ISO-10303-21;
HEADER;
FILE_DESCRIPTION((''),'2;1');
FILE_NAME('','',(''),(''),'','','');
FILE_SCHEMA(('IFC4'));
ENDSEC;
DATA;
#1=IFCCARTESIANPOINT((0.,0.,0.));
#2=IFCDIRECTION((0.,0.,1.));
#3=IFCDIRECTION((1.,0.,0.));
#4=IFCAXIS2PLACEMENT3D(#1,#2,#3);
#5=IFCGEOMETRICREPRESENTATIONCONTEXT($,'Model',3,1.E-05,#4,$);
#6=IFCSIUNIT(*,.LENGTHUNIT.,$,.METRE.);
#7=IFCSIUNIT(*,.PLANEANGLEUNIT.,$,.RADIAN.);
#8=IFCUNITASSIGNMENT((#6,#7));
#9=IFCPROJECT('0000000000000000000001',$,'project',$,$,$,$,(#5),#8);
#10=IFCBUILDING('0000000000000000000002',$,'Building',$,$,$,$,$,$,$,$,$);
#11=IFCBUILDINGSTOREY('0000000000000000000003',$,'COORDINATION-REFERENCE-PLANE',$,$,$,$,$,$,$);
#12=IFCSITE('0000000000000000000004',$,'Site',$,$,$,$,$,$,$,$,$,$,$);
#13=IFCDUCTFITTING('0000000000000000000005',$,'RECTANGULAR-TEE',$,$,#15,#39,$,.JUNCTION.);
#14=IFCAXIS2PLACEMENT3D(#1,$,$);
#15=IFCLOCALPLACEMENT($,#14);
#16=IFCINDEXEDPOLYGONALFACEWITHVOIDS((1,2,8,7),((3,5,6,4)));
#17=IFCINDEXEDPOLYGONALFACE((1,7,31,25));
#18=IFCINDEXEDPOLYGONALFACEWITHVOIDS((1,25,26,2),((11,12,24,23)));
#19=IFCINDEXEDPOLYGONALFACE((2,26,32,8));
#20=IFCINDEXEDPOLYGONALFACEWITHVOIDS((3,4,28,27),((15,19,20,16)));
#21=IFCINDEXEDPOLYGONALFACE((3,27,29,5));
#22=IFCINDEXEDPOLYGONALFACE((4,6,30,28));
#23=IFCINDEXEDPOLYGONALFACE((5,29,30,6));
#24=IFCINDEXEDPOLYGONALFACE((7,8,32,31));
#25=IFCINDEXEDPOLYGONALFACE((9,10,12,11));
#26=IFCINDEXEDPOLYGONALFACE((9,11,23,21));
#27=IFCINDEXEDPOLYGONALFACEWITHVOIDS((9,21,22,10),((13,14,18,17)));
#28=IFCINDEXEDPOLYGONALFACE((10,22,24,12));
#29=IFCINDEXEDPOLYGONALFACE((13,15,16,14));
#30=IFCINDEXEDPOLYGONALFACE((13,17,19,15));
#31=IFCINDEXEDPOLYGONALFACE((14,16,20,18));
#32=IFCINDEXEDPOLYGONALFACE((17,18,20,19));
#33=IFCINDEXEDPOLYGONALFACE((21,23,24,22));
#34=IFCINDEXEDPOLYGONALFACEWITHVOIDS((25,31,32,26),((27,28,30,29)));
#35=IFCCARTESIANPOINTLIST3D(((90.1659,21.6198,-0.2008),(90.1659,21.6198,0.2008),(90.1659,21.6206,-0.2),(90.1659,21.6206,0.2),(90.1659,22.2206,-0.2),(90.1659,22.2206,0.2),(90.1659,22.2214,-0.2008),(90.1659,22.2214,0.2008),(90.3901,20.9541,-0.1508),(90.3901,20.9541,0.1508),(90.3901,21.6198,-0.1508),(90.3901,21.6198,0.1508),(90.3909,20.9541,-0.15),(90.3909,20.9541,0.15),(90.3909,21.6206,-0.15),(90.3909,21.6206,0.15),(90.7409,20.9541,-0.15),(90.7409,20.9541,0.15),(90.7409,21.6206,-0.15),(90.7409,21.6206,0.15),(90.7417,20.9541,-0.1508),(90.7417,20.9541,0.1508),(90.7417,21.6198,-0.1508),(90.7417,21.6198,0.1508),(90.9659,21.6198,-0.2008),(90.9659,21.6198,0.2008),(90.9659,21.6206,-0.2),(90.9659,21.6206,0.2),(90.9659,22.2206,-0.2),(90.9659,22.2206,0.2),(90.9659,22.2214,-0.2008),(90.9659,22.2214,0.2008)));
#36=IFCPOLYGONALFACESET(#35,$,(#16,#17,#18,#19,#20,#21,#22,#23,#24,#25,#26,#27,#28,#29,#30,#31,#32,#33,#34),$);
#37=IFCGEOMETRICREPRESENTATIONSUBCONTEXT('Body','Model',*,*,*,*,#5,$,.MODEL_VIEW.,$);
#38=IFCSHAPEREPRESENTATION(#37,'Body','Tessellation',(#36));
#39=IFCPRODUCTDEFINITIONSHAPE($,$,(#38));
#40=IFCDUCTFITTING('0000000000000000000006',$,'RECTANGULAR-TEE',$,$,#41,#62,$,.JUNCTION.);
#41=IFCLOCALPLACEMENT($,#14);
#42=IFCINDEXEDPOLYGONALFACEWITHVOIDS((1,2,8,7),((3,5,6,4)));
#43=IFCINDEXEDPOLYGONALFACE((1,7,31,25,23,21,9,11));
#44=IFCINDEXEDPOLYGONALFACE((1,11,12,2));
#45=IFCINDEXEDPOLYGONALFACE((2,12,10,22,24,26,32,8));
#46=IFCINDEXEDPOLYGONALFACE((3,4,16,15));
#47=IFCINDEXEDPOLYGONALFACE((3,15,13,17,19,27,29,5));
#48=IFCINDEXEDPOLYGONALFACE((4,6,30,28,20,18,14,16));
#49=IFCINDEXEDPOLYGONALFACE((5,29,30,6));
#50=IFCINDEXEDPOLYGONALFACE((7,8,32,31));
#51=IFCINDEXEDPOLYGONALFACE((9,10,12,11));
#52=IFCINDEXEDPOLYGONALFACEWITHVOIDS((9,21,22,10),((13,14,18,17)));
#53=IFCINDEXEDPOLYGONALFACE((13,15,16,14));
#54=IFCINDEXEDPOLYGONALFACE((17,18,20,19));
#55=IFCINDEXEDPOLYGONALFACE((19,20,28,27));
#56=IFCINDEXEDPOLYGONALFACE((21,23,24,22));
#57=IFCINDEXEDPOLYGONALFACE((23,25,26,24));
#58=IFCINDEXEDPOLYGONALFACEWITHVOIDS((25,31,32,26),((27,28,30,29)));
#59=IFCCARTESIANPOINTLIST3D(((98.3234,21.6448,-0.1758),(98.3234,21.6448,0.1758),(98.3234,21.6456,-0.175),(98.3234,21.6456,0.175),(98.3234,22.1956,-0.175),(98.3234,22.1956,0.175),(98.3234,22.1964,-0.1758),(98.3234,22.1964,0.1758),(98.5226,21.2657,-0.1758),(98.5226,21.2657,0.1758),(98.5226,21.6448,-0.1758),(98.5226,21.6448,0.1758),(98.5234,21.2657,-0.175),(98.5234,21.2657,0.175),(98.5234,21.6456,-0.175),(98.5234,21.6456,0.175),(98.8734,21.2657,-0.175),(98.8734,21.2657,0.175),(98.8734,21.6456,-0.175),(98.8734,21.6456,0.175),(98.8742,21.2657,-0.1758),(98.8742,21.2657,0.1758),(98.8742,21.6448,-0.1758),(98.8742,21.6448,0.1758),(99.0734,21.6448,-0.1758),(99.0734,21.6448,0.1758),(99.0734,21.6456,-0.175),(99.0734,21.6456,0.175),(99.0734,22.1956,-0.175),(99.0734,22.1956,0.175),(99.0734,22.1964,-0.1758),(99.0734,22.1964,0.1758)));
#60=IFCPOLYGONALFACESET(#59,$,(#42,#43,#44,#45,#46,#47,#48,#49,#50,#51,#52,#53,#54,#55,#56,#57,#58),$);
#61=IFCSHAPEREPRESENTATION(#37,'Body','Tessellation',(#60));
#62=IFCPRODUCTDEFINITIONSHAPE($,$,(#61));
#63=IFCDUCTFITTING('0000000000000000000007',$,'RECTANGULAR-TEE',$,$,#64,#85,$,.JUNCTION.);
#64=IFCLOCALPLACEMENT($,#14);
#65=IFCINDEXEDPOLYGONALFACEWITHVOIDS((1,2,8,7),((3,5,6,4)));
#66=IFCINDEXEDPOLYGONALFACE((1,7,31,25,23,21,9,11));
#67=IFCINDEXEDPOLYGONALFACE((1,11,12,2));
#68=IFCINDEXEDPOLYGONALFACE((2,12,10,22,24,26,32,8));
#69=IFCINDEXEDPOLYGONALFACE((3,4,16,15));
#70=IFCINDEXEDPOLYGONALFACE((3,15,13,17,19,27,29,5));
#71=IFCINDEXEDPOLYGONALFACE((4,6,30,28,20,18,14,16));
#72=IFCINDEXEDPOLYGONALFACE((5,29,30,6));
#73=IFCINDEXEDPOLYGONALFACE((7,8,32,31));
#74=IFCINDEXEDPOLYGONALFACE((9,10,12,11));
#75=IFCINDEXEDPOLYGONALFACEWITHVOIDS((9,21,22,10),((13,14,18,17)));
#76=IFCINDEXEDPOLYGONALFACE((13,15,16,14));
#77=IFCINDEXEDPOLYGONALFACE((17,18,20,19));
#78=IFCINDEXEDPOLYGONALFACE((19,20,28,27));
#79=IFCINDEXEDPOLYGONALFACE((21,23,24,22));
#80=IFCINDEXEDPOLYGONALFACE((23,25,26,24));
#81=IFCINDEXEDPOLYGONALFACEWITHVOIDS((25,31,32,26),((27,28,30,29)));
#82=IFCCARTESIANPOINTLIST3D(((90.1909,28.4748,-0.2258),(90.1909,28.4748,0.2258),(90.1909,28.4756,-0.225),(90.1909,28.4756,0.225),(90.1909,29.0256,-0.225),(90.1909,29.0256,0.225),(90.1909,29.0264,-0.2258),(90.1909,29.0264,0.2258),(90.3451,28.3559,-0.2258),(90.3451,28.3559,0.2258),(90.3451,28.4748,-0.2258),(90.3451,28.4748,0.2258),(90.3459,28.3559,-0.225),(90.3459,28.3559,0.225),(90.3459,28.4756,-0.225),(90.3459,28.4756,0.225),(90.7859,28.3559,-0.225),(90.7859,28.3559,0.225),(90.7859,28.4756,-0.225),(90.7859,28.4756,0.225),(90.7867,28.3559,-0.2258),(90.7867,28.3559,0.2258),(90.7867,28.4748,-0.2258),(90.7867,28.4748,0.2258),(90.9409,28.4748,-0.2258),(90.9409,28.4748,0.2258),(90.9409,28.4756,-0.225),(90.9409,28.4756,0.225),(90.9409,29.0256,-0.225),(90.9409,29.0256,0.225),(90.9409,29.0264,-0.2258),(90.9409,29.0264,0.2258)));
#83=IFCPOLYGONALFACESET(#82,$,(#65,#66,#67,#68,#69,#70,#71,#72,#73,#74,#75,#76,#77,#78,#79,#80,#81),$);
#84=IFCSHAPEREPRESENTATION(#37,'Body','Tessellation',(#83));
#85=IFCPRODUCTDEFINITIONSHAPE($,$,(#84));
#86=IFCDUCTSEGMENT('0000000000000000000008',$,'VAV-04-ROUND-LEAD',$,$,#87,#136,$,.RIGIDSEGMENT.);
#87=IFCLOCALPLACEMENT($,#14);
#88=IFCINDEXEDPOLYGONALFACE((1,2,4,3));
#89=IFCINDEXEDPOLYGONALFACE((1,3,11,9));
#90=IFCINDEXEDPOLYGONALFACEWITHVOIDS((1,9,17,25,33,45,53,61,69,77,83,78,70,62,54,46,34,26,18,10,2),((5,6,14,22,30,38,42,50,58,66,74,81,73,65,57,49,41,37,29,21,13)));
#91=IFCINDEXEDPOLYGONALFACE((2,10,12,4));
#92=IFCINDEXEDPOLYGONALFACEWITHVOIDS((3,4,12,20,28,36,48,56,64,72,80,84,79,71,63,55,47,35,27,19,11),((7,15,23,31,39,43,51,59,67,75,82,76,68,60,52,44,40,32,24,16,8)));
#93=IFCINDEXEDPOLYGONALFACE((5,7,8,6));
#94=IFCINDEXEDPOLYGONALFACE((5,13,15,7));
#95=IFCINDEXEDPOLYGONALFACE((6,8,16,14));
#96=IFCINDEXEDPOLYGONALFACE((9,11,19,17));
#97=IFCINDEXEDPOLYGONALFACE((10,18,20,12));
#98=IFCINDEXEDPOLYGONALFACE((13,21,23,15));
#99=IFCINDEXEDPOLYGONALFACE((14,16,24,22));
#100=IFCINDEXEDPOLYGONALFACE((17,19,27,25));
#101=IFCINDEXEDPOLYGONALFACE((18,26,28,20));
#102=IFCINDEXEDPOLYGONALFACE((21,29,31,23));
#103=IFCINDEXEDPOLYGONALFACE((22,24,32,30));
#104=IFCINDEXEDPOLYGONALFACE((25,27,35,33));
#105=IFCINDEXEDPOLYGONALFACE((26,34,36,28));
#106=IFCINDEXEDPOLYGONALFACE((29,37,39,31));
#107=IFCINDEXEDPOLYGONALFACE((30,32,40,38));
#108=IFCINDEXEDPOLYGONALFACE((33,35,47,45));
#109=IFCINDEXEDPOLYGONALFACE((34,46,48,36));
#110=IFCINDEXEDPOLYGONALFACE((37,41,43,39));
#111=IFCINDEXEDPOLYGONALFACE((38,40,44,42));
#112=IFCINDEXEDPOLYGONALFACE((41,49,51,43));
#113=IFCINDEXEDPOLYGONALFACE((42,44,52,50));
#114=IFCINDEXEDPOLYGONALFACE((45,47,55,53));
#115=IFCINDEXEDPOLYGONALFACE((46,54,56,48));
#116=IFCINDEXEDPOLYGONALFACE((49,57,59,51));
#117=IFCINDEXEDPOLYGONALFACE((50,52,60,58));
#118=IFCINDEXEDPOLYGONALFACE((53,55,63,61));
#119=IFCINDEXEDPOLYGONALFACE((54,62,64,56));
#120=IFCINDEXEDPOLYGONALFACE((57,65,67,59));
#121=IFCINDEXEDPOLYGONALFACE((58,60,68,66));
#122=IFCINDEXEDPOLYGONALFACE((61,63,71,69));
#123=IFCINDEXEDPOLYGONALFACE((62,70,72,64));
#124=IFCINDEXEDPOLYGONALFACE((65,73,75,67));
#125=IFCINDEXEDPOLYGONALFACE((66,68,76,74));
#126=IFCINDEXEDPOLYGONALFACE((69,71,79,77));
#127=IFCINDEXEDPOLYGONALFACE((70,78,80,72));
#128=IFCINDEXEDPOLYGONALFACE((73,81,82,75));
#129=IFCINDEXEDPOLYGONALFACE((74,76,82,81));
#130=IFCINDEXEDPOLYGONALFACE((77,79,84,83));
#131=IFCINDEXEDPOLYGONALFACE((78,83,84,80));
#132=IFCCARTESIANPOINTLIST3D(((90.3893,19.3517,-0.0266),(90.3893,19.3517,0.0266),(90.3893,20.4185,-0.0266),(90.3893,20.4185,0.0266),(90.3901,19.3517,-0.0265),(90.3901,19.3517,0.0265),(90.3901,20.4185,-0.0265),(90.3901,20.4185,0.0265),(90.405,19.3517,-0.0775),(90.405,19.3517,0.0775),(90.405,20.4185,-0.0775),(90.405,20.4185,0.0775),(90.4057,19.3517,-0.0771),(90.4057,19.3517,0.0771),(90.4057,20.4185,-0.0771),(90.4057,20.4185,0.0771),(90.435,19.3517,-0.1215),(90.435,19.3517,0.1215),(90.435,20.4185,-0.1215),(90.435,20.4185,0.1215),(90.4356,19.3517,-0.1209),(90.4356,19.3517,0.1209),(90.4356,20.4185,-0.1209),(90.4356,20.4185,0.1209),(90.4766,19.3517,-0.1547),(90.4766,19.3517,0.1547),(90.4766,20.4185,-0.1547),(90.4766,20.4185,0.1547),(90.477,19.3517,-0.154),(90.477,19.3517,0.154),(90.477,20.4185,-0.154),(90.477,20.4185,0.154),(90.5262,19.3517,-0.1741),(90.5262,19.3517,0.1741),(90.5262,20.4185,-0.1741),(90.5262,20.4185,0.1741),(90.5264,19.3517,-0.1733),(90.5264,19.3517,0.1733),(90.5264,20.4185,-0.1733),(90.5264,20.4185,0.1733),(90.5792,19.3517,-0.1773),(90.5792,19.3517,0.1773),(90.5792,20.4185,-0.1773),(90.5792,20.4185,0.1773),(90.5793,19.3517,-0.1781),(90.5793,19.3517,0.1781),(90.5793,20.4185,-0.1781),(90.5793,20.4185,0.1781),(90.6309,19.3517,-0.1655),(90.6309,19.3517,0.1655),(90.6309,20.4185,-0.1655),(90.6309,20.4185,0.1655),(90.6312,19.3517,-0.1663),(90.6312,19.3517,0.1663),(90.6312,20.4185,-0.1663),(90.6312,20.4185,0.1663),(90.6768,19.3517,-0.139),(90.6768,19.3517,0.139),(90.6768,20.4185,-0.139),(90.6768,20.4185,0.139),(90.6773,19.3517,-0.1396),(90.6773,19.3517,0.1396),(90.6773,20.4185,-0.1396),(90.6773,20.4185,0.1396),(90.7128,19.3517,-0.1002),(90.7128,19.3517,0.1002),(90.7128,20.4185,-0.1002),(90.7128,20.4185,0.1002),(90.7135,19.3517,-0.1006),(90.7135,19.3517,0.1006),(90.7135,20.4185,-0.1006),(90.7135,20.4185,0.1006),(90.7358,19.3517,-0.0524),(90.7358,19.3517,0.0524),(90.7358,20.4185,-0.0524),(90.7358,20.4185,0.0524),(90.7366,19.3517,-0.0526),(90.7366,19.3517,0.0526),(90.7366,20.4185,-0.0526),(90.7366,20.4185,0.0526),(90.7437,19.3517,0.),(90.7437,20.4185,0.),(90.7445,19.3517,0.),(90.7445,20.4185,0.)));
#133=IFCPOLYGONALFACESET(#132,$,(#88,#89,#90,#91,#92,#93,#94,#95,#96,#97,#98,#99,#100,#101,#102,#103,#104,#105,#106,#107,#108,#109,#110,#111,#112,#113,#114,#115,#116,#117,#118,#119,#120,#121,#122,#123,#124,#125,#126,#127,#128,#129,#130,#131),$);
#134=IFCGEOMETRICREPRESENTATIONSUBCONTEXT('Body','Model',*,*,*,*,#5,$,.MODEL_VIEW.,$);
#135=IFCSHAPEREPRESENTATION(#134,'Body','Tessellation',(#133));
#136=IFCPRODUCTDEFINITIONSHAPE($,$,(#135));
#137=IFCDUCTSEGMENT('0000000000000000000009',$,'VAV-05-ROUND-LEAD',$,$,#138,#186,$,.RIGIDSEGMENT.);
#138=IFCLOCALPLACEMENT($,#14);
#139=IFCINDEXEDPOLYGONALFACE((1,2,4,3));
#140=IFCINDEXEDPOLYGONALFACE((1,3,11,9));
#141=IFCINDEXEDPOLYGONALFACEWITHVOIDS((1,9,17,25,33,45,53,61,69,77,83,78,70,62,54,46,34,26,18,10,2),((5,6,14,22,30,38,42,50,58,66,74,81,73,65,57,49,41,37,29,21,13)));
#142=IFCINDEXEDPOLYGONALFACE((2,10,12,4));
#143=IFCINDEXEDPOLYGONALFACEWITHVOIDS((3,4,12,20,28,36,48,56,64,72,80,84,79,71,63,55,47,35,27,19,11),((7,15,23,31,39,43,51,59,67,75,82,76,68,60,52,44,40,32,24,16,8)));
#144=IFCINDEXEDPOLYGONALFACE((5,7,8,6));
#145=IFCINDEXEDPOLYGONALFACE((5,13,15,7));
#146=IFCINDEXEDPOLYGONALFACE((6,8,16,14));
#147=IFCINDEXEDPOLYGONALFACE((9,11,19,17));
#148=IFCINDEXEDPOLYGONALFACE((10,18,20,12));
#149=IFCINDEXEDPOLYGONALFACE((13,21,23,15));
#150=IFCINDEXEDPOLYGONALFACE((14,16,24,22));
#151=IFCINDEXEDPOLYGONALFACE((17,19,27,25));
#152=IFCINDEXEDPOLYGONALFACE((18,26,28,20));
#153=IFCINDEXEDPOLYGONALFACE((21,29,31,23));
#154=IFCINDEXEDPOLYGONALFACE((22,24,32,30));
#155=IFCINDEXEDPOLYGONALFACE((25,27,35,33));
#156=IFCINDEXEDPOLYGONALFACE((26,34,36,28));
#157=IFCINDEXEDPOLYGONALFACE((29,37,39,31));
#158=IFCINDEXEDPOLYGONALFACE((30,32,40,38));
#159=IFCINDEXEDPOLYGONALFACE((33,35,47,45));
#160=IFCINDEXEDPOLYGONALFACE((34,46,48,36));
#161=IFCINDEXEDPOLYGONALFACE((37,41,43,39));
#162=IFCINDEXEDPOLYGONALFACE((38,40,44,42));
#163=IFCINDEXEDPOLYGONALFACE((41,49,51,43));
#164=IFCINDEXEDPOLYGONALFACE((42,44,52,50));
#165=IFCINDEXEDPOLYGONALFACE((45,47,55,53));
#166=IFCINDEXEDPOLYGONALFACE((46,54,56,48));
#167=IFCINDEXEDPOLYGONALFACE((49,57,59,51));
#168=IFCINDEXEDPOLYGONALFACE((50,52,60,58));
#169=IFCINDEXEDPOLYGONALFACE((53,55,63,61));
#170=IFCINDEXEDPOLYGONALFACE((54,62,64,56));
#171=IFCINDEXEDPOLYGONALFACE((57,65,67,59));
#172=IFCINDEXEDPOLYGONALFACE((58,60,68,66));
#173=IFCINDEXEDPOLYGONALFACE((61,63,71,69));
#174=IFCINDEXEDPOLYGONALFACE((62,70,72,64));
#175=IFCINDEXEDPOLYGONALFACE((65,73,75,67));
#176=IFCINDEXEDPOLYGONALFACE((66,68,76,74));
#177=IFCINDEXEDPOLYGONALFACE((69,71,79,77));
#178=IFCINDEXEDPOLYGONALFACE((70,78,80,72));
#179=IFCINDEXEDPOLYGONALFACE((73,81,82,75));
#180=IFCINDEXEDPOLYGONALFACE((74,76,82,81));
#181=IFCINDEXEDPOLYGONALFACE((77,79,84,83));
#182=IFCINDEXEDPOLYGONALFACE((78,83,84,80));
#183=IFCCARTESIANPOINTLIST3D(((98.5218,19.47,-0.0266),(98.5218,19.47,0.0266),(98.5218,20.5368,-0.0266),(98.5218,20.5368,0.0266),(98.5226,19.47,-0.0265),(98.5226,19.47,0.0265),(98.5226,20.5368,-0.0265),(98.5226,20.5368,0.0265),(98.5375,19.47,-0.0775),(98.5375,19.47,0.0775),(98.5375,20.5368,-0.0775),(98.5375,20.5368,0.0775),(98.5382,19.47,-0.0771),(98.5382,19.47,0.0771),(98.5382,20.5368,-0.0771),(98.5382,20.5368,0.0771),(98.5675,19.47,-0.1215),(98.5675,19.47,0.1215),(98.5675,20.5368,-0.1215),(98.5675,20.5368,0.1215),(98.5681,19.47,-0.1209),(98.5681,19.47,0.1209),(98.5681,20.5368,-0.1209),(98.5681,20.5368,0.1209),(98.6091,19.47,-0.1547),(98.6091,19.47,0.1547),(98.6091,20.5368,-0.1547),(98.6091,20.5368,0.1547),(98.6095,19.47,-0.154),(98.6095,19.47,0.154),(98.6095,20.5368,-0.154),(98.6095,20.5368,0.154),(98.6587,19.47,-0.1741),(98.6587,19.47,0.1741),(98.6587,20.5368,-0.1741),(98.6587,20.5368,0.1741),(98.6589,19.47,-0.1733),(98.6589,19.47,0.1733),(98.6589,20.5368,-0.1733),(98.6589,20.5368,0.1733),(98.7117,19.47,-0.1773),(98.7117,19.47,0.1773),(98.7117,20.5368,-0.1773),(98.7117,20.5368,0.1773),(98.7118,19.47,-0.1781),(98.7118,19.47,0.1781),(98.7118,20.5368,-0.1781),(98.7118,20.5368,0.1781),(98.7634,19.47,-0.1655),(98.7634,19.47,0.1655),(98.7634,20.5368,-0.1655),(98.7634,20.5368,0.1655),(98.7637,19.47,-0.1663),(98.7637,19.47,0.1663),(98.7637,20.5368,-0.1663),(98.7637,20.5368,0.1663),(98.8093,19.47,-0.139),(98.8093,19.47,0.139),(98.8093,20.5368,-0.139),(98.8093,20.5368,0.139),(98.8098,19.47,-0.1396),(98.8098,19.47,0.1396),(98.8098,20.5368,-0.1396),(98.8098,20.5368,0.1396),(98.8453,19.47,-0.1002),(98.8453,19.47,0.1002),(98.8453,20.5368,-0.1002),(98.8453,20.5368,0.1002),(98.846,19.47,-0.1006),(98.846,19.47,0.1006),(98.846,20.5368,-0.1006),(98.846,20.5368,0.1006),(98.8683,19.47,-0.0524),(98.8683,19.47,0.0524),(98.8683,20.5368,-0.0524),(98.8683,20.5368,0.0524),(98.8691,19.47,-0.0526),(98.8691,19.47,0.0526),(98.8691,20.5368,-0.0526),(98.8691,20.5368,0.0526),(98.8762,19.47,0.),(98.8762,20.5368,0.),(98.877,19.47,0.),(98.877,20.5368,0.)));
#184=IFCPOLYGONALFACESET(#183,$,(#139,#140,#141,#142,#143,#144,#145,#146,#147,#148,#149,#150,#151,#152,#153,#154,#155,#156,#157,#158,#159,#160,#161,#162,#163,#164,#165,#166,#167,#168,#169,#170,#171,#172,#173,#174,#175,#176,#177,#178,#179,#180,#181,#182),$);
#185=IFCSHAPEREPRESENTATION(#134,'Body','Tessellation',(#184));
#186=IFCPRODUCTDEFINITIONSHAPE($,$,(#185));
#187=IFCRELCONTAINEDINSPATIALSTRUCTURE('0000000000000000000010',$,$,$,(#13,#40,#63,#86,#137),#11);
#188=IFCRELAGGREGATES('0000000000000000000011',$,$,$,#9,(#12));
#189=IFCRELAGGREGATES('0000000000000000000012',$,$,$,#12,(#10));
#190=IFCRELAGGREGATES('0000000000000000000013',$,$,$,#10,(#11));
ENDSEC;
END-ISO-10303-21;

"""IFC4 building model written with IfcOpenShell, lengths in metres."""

from ifc_helpers import new_model, si_unit, frame, origin, origin_with_axes, place, context, subcontext, project, spatial, rectangle, hollow_circle, extrude, boolean, element, save


model = new_model("IFC4")

# Units and contexts
model_context = context("Model", 3, precision=1e-05, world=origin_with_axes())
body_context_1 = subcontext(model_context, "Body", "Model", "MODEL_VIEW")
body_context_2 = subcontext(model_context, "Body", "Model", "MODEL_VIEW")
ifc_project = project(units=[si_unit("LENGTHUNIT", "METRE"), si_unit("PLANEANGLEUNIT", "RADIAN")], contexts=[model_context])

# Site, building, storey
site = spatial("IfcSite", under=ifc_project, Name="Site")
building = spatial("IfcBuilding", under=site, Name="Building")
storey = spatial("IfcBuildingStorey", under=building, Name="COORDINATION-REFERENCE-PLANE")

# Duct fittings
duct_fitting_1_placement = place(None, frame((90.5659, 21.9206, 0.0), z_axis=(1.0, 0.0, 0.0), x_axis=(0.0, -1.0, 0.0)))
solid_1 = boolean("UNION", extrude(rectangle(XDim=0.6, YDim=0.4), frame((0.0, 0.0, -0.4), z_axis=(0.0, 0.0, 1.0), x_axis=(1.0, 0.0, 0.0)), (0.0, 0.0, 1.0), 0.8), extrude(rectangle(XDim=0.35, YDim=0.3), frame((0.0, 0.0, 0.0), z_axis=(1.0, 0.0, 0.0), x_axis=(0.0, 0.0, -1.0)), (0.0, 0.0, 1.0), 0.9665))
element("IfcDuctFitting", 1, at=duct_fitting_1_placement, inside=storey, Name="RECTANGULAR-TEE", PredefinedType="JUNCTION", context=body_context_1, shape_type="CSG", body=[
    boolean("DIFFERENCE", boolean("UNION", extrude(rectangle(XDim=0.6016, YDim=0.4016), frame((0.0, 0.0, -0.4), z_axis=(0.0, 0.0, 1.0), x_axis=(1.0, 0.0, 0.0)), (0.0, 0.0, 1.0), 0.8), extrude(rectangle(XDim=0.3516, YDim=0.3016), frame((0.0, 0.0, 0.0), z_axis=(1.0, 0.0, 0.0), x_axis=(0.0, 0.0, -1.0)), (0.0, 0.0, 1.0), 0.9665)), solid_1),
])
duct_fitting_2_placement = place(None, frame((98.6984, 21.9206, 0.0), z_axis=(1.0, 0.0, 0.0), x_axis=(0.0, -1.0, 0.0)))
solid_2 = boolean("UNION", extrude(rectangle(XDim=0.55, YDim=0.35), frame((0.0, 0.0, -0.375), z_axis=(0.0, 0.0, 1.0), x_axis=(1.0, 0.0, 0.0)), (0.0, 0.0, 1.0), 0.75), extrude(rectangle(XDim=0.35, YDim=0.35), frame((0.0, 0.0, 0.0), z_axis=(1.0, 0.0, 0.0), x_axis=(0.0, 0.0, -1.0)), (0.0, 0.0, 1.0), 0.6549))
element("IfcDuctFitting", 2, at=duct_fitting_2_placement, inside=storey, Name="RECTANGULAR-TEE", PredefinedType="JUNCTION", context=body_context_1, shape_type="CSG", body=[
    boolean("DIFFERENCE", boolean("UNION", extrude(rectangle(XDim=0.5516, YDim=0.3516), frame((0.0, 0.0, -0.375), z_axis=(0.0, 0.0, 1.0), x_axis=(1.0, 0.0, 0.0)), (0.0, 0.0, 1.0), 0.75), extrude(rectangle(XDim=0.3516, YDim=0.3516), frame((0.0, 0.0, 0.0), z_axis=(1.0, 0.0, 0.0), x_axis=(0.0, 0.0, -1.0)), (0.0, 0.0, 1.0), 0.6549)), solid_2),
])
duct_fitting_3_placement = place(None, frame((90.5659, 28.7506, 0.0), z_axis=(1.0, 0.0, 0.0), x_axis=(0.0, -1.0, 0.0)))
solid_3 = boolean("UNION", extrude(rectangle(XDim=0.55, YDim=0.45), frame((0.0, 0.0, -0.375), z_axis=(0.0, 0.0, 1.0), x_axis=(1.0, 0.0, 0.0)), (0.0, 0.0, 1.0), 0.75), extrude(rectangle(XDim=0.44, YDim=0.45), frame((0.0, 0.0, 0.0), z_axis=(1.0, 0.0, 0.0), x_axis=(0.0, 0.0, -1.0)), (0.0, 0.0, 1.0), 0.3947))
element("IfcDuctFitting", 3, at=duct_fitting_3_placement, inside=storey, Name="RECTANGULAR-TEE", PredefinedType="JUNCTION", context=body_context_1, shape_type="CSG", body=[
    boolean("DIFFERENCE", boolean("UNION", extrude(rectangle(XDim=0.5516, YDim=0.4516), frame((0.0, 0.0, -0.375), z_axis=(0.0, 0.0, 1.0), x_axis=(1.0, 0.0, 0.0)), (0.0, 0.0, 1.0), 0.75), extrude(rectangle(XDim=0.4416, YDim=0.4516), frame((0.0, 0.0, 0.0), z_axis=(1.0, 0.0, 0.0), x_axis=(0.0, 0.0, -1.0)), (0.0, 0.0, 1.0), 0.3947)), solid_3),
])

# Duct segments
for number, where, z_axis, x_axis, name in (
    (4, (90.5659, 20.4185, 0.0), (0.0, -1.0, 0.0), (1.0, 0.0, 0.0), "VAV-04-ROUND-LEAD"),
    (5, (98.6984, 20.5368, 0.0), (0.0, -1.0, 0.0), (1.0, 0.0, 0.0), "VAV-05-ROUND-LEAD"),
):
    element("IfcDuctSegment", number, at=place(None, frame(where, z_axis=z_axis, x_axis=x_axis)), inside=storey, Name=name, PredefinedType="RIGIDSEGMENT", context=body_context_2, shape_type="SweptSolid", body=[
        extrude(hollow_circle(Radius=0.1786, WallThickness=0.0008), origin(), (0.0, 0.0, 1.0), 1.0668),
    ])

save(model, "model.ifc")
